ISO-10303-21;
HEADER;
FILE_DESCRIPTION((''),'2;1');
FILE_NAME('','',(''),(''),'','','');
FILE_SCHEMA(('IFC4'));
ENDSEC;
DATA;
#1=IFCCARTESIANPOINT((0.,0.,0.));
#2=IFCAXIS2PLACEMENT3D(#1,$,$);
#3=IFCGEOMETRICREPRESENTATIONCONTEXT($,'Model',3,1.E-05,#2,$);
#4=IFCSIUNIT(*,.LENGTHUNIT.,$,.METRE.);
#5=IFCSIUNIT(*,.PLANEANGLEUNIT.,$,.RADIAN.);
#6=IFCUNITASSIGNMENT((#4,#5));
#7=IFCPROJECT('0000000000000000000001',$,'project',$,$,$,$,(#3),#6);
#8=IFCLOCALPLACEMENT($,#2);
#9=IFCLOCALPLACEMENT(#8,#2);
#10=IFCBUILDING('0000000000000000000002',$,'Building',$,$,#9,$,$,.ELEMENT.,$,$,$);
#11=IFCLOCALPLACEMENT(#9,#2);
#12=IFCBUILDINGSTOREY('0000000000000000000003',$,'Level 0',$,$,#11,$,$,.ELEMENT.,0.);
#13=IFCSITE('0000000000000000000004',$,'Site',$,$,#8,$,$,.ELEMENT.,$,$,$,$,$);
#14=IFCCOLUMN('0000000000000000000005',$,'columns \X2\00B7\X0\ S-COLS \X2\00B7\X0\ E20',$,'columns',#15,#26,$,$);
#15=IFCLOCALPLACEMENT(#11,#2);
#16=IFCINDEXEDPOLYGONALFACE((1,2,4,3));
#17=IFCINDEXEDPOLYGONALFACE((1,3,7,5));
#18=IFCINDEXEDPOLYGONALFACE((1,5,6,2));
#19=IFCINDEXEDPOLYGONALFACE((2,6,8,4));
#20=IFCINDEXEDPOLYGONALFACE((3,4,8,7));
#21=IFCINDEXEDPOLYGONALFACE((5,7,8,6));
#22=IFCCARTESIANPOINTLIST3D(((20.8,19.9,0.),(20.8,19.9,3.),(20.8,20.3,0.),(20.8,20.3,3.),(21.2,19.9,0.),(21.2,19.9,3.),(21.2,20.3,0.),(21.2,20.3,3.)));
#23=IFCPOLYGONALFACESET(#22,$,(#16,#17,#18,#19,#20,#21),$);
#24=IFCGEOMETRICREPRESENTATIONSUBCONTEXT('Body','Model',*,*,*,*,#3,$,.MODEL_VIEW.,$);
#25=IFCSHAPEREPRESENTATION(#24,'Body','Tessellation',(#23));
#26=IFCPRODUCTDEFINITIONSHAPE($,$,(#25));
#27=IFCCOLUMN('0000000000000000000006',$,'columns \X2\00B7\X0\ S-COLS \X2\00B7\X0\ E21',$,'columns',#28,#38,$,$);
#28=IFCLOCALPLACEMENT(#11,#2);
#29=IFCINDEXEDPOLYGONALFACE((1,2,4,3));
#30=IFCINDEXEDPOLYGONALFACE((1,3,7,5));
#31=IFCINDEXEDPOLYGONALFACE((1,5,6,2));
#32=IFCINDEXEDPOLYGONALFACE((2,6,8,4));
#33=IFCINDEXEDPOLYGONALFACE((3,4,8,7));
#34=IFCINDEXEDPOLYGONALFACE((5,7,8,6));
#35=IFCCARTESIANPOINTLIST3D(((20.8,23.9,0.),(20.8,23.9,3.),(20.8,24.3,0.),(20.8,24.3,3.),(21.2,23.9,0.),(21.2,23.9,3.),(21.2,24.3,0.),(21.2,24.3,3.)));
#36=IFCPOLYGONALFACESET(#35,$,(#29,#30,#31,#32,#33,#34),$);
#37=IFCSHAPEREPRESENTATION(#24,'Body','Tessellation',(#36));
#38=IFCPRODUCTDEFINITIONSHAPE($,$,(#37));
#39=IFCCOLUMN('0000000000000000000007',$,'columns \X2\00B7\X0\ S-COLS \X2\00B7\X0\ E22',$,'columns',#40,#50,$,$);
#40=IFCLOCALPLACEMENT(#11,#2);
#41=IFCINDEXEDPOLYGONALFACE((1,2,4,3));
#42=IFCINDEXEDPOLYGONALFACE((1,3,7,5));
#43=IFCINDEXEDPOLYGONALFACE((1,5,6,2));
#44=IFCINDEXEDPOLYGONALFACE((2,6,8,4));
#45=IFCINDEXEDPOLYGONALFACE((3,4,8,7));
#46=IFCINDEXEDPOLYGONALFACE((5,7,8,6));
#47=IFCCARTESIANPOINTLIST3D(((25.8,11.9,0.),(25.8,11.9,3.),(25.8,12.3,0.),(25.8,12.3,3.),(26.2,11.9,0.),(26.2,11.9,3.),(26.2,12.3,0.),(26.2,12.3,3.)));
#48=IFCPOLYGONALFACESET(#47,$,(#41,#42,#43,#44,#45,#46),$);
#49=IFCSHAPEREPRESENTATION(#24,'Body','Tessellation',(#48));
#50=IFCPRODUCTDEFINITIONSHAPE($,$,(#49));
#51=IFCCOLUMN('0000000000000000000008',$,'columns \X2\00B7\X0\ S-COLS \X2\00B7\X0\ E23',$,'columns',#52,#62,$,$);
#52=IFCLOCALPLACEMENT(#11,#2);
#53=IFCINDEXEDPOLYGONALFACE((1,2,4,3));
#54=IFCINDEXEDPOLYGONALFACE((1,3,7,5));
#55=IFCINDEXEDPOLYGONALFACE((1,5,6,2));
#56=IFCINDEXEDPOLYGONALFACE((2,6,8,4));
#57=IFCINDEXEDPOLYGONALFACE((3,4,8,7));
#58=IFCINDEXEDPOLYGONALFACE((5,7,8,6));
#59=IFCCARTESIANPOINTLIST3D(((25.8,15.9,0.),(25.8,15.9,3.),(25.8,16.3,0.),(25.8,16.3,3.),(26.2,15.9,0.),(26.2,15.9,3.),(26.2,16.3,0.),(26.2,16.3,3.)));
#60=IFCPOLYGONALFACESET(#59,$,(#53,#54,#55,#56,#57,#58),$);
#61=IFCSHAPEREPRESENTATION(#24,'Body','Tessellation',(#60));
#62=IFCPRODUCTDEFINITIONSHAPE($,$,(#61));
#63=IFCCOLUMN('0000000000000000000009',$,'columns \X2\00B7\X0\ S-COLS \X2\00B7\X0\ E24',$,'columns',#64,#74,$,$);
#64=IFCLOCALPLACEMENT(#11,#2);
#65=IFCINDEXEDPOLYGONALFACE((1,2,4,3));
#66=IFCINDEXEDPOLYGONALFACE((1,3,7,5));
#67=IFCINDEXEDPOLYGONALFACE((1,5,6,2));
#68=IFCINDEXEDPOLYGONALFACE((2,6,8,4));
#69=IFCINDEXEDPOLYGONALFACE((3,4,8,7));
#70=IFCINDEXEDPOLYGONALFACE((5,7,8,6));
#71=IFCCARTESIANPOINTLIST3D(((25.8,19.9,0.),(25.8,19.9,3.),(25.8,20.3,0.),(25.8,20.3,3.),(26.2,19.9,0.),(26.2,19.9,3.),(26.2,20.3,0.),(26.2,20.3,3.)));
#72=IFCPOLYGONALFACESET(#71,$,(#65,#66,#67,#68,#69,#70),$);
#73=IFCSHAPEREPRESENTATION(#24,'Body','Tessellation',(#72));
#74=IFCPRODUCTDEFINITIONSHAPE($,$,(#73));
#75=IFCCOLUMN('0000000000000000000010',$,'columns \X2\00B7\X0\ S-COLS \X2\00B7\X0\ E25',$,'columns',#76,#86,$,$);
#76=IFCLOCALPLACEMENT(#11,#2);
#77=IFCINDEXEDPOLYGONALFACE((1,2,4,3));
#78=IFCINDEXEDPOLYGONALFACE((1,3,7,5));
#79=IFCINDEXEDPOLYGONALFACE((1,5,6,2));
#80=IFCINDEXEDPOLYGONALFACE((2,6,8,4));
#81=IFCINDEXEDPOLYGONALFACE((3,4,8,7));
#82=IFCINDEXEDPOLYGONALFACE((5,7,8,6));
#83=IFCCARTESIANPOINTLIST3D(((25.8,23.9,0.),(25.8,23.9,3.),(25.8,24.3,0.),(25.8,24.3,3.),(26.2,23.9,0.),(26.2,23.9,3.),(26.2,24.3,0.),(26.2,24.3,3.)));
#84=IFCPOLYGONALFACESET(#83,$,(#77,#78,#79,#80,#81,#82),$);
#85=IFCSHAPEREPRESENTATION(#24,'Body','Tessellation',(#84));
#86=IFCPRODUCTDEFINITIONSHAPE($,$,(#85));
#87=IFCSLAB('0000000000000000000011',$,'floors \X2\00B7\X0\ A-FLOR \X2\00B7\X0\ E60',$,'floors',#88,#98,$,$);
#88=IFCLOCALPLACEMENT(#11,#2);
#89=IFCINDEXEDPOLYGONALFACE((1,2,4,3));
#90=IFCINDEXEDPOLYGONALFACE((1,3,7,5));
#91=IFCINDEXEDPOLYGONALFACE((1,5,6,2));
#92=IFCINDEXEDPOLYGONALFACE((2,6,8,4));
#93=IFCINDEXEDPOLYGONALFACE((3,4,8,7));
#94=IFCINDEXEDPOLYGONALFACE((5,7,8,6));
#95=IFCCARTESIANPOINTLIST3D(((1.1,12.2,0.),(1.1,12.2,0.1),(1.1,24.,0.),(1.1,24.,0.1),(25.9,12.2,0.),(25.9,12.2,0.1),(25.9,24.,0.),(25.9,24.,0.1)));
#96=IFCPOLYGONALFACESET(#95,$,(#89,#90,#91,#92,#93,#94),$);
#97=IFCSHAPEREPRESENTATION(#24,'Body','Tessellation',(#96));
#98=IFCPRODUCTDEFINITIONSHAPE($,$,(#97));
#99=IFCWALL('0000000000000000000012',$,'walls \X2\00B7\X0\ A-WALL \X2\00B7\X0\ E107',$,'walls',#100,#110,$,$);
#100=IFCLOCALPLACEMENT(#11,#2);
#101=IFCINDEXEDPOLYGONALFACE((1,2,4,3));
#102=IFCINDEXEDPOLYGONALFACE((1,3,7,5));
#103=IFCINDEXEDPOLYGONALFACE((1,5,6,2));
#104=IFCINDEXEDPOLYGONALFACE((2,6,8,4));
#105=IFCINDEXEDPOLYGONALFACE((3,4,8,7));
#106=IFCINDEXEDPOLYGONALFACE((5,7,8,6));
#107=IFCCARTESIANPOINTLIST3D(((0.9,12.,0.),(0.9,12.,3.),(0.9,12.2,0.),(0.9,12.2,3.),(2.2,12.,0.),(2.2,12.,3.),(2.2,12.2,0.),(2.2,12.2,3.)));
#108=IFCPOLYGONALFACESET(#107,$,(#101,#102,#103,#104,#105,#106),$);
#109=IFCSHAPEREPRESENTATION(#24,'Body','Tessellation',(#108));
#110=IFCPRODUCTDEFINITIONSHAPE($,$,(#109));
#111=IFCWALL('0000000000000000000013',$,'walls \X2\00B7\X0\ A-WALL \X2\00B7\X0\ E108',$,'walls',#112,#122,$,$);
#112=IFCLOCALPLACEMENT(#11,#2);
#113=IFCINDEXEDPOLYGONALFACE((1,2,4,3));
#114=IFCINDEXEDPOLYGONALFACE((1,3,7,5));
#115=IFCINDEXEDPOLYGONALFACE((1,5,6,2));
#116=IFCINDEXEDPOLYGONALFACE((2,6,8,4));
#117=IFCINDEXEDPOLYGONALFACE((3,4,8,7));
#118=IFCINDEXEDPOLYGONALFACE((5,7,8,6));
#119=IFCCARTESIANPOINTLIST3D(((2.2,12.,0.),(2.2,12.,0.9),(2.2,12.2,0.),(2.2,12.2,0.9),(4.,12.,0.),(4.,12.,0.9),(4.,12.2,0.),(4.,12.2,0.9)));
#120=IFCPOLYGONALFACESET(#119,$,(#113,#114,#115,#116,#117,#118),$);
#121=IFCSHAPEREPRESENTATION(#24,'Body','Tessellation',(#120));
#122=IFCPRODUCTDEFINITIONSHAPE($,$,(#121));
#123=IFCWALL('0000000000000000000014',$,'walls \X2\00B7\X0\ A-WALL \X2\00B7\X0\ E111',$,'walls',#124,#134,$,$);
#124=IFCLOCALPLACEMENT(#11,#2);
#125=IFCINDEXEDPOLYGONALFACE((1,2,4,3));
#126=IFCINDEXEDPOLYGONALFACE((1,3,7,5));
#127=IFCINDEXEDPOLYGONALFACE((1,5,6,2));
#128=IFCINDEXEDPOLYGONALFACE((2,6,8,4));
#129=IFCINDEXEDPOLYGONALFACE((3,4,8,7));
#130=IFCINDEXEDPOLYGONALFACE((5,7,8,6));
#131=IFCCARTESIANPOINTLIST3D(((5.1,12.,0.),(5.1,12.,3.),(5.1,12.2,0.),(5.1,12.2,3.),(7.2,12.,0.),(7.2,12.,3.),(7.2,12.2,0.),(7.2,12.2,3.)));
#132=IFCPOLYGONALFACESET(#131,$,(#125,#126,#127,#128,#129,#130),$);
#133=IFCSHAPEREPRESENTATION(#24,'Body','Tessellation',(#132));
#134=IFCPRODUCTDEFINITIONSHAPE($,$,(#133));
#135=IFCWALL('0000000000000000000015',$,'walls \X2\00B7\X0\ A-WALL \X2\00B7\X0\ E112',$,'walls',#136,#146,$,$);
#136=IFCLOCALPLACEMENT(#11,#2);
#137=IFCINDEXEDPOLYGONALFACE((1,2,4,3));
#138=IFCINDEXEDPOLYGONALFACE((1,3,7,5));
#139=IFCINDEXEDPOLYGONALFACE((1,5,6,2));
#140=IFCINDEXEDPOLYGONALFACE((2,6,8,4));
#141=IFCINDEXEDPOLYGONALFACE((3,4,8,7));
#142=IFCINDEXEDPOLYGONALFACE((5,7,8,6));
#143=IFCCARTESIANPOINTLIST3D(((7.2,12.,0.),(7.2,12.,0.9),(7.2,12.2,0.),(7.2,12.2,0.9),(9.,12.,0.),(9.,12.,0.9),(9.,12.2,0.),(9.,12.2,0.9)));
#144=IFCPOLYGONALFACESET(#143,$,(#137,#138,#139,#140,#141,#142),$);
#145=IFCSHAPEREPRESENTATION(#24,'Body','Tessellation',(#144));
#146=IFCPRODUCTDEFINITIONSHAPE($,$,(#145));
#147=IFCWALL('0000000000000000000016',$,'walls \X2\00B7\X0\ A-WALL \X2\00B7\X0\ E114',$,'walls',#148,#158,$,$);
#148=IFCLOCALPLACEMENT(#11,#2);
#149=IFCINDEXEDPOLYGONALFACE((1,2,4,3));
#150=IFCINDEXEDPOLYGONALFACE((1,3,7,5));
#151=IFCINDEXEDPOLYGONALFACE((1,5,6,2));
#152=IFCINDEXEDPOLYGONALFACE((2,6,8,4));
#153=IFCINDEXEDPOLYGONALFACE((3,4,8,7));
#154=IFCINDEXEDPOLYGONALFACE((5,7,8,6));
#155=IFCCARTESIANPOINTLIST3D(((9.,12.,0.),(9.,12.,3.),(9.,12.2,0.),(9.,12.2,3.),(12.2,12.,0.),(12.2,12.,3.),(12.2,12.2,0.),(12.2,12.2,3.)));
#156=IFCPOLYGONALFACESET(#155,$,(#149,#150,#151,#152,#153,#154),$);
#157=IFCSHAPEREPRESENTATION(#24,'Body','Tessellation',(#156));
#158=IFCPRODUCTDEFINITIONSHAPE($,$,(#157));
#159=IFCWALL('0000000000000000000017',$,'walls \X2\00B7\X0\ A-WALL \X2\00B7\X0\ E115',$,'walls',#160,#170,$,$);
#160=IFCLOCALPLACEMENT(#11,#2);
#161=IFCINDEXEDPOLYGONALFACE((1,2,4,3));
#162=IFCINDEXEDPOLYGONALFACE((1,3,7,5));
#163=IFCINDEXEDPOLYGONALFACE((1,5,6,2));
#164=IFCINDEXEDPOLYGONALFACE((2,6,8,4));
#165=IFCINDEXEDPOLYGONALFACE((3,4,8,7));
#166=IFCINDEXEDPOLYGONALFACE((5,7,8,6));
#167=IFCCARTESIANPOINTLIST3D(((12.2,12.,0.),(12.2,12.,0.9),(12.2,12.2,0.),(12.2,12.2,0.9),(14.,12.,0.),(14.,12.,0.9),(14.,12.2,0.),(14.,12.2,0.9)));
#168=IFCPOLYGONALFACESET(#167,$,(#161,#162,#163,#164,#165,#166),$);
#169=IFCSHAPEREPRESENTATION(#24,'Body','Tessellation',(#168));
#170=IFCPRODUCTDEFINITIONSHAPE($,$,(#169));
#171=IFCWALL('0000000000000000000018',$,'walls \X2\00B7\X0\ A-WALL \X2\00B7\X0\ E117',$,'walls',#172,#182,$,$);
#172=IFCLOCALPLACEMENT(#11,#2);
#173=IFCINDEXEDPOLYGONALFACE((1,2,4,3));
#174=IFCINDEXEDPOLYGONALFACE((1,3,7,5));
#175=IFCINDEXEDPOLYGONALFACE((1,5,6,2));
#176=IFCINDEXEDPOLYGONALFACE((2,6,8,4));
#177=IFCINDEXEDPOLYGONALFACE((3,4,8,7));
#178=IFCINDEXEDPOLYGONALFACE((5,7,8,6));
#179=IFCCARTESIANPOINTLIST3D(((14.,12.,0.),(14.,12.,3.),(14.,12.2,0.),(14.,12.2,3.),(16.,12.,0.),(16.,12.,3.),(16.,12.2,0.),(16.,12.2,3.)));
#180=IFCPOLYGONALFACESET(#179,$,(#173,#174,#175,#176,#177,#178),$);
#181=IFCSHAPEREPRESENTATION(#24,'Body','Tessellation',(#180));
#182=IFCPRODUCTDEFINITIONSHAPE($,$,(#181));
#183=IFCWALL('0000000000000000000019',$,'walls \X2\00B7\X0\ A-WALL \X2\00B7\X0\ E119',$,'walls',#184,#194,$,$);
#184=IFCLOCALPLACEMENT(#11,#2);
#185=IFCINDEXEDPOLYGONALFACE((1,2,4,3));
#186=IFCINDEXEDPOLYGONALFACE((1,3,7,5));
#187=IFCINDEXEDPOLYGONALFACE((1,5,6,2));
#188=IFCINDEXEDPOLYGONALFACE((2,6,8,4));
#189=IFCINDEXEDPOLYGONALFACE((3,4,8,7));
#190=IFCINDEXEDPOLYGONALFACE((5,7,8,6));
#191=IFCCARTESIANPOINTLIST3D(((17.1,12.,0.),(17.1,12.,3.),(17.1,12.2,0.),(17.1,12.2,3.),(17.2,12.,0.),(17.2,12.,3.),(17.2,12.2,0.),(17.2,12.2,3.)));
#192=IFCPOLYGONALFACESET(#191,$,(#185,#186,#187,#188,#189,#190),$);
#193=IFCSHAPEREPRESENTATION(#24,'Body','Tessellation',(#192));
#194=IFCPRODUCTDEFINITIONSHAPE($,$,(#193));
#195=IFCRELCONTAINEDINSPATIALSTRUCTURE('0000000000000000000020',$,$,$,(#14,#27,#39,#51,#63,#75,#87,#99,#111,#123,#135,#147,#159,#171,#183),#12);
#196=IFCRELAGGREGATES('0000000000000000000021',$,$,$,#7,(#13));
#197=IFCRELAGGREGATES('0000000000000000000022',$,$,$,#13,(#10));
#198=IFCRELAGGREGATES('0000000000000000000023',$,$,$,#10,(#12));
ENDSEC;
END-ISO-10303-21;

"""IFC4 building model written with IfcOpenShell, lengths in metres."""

from ifc_helpers import new_model, si_unit, frame, origin, place, context, subcontext, project, spatial, polyline, outline, extrude, element, save


model = new_model("IFC4")

# Units and contexts
model_context = context("Model", 3, precision=1e-05, world=origin())
body_context = subcontext(model_context, "Body", "Model", "MODEL_VIEW")
ifc_project = project(units=[si_unit("LENGTHUNIT", "METRE"), si_unit("PLANEANGLEUNIT", "RADIAN")], contexts=[model_context])

# Site, building, storey
site_placement = place(None, origin())
site = spatial("IfcSite", under=ifc_project, at=site_placement, Name="Site", CompositionType="ELEMENT")
building_placement = place(site_placement, origin())
building = spatial("IfcBuilding", under=site, at=building_placement, Name="Building", CompositionType="ELEMENT")
storey_placement = place(building_placement, origin())
storey = spatial("IfcBuildingStorey", under=building, at=storey_placement, Name="Level 0", CompositionType="ELEMENT", Elevation=0.0)

# Columns
column_1_placement = place(storey_placement, origin())
element("IfcColumn", 1, at=column_1_placement, inside=storey, Name="columns · S-COLS · E20", ObjectType="columns", context=body_context, shape_type="SweptSolid", body=[
    extrude(outline(polyline([(20.8, 19.9), (21.2, 19.9), (21.2, 20.3), (20.8, 20.3), (20.8, 19.9)])), origin(), (0.0, 0.0, 1.0), 3.0),
])
column_2_placement = place(storey_placement, origin())
element("IfcColumn", 2, at=column_2_placement, inside=storey, Name="columns · S-COLS · E21", ObjectType="columns", context=body_context, shape_type="SweptSolid", body=[
    extrude(outline(polyline([(20.8, 23.9), (21.2, 23.9), (21.2, 24.3), (20.8, 24.3), (20.8, 23.9)])), origin(), (0.0, 0.0, 1.0), 3.0),
])
column_3_placement = place(storey_placement, origin())
element("IfcColumn", 3, at=column_3_placement, inside=storey, Name="columns · S-COLS · E22", ObjectType="columns", context=body_context, shape_type="SweptSolid", body=[
    extrude(outline(polyline([(25.8, 11.9), (26.2, 11.9), (26.2, 12.3), (25.8, 12.3), (25.8, 11.9)])), origin(), (0.0, 0.0, 1.0), 3.0),
])
column_4_placement = place(storey_placement, origin())
element("IfcColumn", 4, at=column_4_placement, inside=storey, Name="columns · S-COLS · E23", ObjectType="columns", context=body_context, shape_type="SweptSolid", body=[
    extrude(outline(polyline([(25.8, 15.9), (26.2, 15.9), (26.2, 16.3), (25.8, 16.3), (25.8, 15.9)])), origin(), (0.0, 0.0, 1.0), 3.0),
])
column_5_placement = place(storey_placement, origin())
element("IfcColumn", 5, at=column_5_placement, inside=storey, Name="columns · S-COLS · E24", ObjectType="columns", context=body_context, shape_type="SweptSolid", body=[
    extrude(outline(polyline([(25.8, 19.9), (26.2, 19.9), (26.2, 20.3), (25.8, 20.3), (25.8, 19.9)])), origin(), (0.0, 0.0, 1.0), 3.0),
])
column_6_placement = place(storey_placement, origin())
element("IfcColumn", 6, at=column_6_placement, inside=storey, Name="columns · S-COLS · E25", ObjectType="columns", context=body_context, shape_type="SweptSolid", body=[
    extrude(outline(polyline([(25.8, 23.9), (26.2, 23.9), (26.2, 24.3), (25.8, 24.3), (25.8, 23.9)])), origin(), (0.0, 0.0, 1.0), 3.0),
])

# Slab
slab_placement = place(storey_placement, origin())
element("IfcSlab", 7, at=slab_placement, inside=storey, Name="floors · A-FLOR · E60", ObjectType="floors", context=body_context, shape_type="SweptSolid", body=[
    extrude(outline(polyline([(1.1, 12.2), (25.9, 12.2), (25.9, 24.0), (1.1, 24.0), (1.1, 12.2)])), origin(), (0.0, 0.0, 1.0), 0.1),
])

# Wall
wall_1_placement = place(storey_placement, origin())
element("IfcWall", 8, at=wall_1_placement, inside=storey, Name="walls · A-WALL · E107", ObjectType="walls", context=body_context, shape_type="SweptSolid", body=[
    extrude(outline(polyline([(0.9, 12.0), (2.2, 12.0), (2.2, 12.2), (0.9, 12.2), (0.9, 12.0)])), origin(), (0.0, 0.0, 1.0), 3.0),
])

# Wall, opening
wall_2_placement = place(storey_placement, origin())
wall_2 = element("IfcWall", 9, at=wall_2_placement, inside=storey, Name="walls · A-WALL · E108", ObjectType="walls", context=body_context, shape_type="SweptSolid", body=[
    extrude(outline(polyline([(2.2, 12.0), (4.0, 12.0), (4.0, 12.2), (2.2, 12.2), (2.2, 12.0)])), origin(), (0.0, 0.0, 1.0), 0.9),
])
opening_1_placement = place(storey_placement, frame((0.0, 0.0, 0.9)))
element("IfcOpeningElement", 10, at=opening_1_placement, cuts=wall_2, ObjectType="Opening", context=body_context, shape_type="SweptSolid", body=[
    extrude(outline(polyline([(2.2, 12.0), (4.0, 12.0), (4.0, 12.2), (2.2, 12.2), (2.2, 12.0)])), origin(), (0.0, 0.0, 1.0), 1.4),
])

# Wall
wall_3_placement = place(storey_placement, origin())
element("IfcWall", 11, at=wall_3_placement, inside=storey, Name="walls · A-WALL · E111", ObjectType="walls", context=body_context, shape_type="SweptSolid", body=[
    extrude(outline(polyline([(5.1, 12.0), (7.2, 12.0), (7.2, 12.2), (5.1, 12.2), (5.1, 12.0)])), origin(), (0.0, 0.0, 1.0), 3.0),
])

# Wall, opening
wall_4_placement = place(storey_placement, origin())
wall_4 = element("IfcWall", 12, at=wall_4_placement, inside=storey, Name="walls · A-WALL · E112", ObjectType="walls", context=body_context, shape_type="SweptSolid", body=[
    extrude(outline(polyline([(7.2, 12.0), (9.0, 12.0), (9.0, 12.2), (7.2, 12.2), (7.2, 12.0)])), origin(), (0.0, 0.0, 1.0), 0.9),
])
opening_2_placement = place(storey_placement, frame((0.0, 0.0, 0.9)))
element("IfcOpeningElement", 13, at=opening_2_placement, cuts=wall_4, ObjectType="Opening", context=body_context, shape_type="SweptSolid", body=[
    extrude(outline(polyline([(7.2, 12.0), (9.0, 12.0), (9.0, 12.2), (7.2, 12.2), (7.2, 12.0)])), origin(), (0.0, 0.0, 1.0), 1.4),
])

# Wall
wall_5_placement = place(storey_placement, origin())
element("IfcWall", 14, at=wall_5_placement, inside=storey, Name="walls · A-WALL · E114", ObjectType="walls", context=body_context, shape_type="SweptSolid", body=[
    extrude(outline(polyline([(9.0, 12.0), (12.2, 12.0), (12.2, 12.2), (9.0, 12.2), (9.0, 12.0)])), origin(), (0.0, 0.0, 1.0), 3.0),
])

# Wall, opening
wall_6_placement = place(storey_placement, origin())
wall_6 = element("IfcWall", 15, at=wall_6_placement, inside=storey, Name="walls · A-WALL · E115", ObjectType="walls", context=body_context, shape_type="SweptSolid", body=[
    extrude(outline(polyline([(12.2, 12.0), (14.0, 12.0), (14.0, 12.2), (12.2, 12.2), (12.2, 12.0)])), origin(), (0.0, 0.0, 1.0), 0.9),
])
opening_3_placement = place(storey_placement, frame((0.0, 0.0, 0.9)))
element("IfcOpeningElement", 16, at=opening_3_placement, cuts=wall_6, ObjectType="Opening", context=body_context, shape_type="SweptSolid", body=[
    extrude(outline(polyline([(12.2, 12.0), (14.0, 12.0), (14.0, 12.2), (12.2, 12.2), (12.2, 12.0)])), origin(), (0.0, 0.0, 1.0), 1.4),
])

# Walls
wall_7_placement = place(storey_placement, origin())
element("IfcWall", 17, at=wall_7_placement, inside=storey, Name="walls · A-WALL · E117", ObjectType="walls", context=body_context, shape_type="SweptSolid", body=[
    extrude(outline(polyline([(14.0, 12.0), (16.0, 12.0), (16.0, 12.2), (14.0, 12.2), (14.0, 12.0)])), origin(), (0.0, 0.0, 1.0), 3.0),
])
wall_8_placement = place(storey_placement, origin())
element("IfcWall", 18, at=wall_8_placement, inside=storey, Name="walls · A-WALL · E119", ObjectType="walls", context=body_context, shape_type="SweptSolid", body=[
    extrude(outline(polyline([(17.1, 12.0), (17.2, 12.0), (17.2, 12.2), (17.1, 12.2), (17.1, 12.0)])), origin(), (0.0, 0.0, 1.0), 3.0),
])

save(model, "model.ifc")
